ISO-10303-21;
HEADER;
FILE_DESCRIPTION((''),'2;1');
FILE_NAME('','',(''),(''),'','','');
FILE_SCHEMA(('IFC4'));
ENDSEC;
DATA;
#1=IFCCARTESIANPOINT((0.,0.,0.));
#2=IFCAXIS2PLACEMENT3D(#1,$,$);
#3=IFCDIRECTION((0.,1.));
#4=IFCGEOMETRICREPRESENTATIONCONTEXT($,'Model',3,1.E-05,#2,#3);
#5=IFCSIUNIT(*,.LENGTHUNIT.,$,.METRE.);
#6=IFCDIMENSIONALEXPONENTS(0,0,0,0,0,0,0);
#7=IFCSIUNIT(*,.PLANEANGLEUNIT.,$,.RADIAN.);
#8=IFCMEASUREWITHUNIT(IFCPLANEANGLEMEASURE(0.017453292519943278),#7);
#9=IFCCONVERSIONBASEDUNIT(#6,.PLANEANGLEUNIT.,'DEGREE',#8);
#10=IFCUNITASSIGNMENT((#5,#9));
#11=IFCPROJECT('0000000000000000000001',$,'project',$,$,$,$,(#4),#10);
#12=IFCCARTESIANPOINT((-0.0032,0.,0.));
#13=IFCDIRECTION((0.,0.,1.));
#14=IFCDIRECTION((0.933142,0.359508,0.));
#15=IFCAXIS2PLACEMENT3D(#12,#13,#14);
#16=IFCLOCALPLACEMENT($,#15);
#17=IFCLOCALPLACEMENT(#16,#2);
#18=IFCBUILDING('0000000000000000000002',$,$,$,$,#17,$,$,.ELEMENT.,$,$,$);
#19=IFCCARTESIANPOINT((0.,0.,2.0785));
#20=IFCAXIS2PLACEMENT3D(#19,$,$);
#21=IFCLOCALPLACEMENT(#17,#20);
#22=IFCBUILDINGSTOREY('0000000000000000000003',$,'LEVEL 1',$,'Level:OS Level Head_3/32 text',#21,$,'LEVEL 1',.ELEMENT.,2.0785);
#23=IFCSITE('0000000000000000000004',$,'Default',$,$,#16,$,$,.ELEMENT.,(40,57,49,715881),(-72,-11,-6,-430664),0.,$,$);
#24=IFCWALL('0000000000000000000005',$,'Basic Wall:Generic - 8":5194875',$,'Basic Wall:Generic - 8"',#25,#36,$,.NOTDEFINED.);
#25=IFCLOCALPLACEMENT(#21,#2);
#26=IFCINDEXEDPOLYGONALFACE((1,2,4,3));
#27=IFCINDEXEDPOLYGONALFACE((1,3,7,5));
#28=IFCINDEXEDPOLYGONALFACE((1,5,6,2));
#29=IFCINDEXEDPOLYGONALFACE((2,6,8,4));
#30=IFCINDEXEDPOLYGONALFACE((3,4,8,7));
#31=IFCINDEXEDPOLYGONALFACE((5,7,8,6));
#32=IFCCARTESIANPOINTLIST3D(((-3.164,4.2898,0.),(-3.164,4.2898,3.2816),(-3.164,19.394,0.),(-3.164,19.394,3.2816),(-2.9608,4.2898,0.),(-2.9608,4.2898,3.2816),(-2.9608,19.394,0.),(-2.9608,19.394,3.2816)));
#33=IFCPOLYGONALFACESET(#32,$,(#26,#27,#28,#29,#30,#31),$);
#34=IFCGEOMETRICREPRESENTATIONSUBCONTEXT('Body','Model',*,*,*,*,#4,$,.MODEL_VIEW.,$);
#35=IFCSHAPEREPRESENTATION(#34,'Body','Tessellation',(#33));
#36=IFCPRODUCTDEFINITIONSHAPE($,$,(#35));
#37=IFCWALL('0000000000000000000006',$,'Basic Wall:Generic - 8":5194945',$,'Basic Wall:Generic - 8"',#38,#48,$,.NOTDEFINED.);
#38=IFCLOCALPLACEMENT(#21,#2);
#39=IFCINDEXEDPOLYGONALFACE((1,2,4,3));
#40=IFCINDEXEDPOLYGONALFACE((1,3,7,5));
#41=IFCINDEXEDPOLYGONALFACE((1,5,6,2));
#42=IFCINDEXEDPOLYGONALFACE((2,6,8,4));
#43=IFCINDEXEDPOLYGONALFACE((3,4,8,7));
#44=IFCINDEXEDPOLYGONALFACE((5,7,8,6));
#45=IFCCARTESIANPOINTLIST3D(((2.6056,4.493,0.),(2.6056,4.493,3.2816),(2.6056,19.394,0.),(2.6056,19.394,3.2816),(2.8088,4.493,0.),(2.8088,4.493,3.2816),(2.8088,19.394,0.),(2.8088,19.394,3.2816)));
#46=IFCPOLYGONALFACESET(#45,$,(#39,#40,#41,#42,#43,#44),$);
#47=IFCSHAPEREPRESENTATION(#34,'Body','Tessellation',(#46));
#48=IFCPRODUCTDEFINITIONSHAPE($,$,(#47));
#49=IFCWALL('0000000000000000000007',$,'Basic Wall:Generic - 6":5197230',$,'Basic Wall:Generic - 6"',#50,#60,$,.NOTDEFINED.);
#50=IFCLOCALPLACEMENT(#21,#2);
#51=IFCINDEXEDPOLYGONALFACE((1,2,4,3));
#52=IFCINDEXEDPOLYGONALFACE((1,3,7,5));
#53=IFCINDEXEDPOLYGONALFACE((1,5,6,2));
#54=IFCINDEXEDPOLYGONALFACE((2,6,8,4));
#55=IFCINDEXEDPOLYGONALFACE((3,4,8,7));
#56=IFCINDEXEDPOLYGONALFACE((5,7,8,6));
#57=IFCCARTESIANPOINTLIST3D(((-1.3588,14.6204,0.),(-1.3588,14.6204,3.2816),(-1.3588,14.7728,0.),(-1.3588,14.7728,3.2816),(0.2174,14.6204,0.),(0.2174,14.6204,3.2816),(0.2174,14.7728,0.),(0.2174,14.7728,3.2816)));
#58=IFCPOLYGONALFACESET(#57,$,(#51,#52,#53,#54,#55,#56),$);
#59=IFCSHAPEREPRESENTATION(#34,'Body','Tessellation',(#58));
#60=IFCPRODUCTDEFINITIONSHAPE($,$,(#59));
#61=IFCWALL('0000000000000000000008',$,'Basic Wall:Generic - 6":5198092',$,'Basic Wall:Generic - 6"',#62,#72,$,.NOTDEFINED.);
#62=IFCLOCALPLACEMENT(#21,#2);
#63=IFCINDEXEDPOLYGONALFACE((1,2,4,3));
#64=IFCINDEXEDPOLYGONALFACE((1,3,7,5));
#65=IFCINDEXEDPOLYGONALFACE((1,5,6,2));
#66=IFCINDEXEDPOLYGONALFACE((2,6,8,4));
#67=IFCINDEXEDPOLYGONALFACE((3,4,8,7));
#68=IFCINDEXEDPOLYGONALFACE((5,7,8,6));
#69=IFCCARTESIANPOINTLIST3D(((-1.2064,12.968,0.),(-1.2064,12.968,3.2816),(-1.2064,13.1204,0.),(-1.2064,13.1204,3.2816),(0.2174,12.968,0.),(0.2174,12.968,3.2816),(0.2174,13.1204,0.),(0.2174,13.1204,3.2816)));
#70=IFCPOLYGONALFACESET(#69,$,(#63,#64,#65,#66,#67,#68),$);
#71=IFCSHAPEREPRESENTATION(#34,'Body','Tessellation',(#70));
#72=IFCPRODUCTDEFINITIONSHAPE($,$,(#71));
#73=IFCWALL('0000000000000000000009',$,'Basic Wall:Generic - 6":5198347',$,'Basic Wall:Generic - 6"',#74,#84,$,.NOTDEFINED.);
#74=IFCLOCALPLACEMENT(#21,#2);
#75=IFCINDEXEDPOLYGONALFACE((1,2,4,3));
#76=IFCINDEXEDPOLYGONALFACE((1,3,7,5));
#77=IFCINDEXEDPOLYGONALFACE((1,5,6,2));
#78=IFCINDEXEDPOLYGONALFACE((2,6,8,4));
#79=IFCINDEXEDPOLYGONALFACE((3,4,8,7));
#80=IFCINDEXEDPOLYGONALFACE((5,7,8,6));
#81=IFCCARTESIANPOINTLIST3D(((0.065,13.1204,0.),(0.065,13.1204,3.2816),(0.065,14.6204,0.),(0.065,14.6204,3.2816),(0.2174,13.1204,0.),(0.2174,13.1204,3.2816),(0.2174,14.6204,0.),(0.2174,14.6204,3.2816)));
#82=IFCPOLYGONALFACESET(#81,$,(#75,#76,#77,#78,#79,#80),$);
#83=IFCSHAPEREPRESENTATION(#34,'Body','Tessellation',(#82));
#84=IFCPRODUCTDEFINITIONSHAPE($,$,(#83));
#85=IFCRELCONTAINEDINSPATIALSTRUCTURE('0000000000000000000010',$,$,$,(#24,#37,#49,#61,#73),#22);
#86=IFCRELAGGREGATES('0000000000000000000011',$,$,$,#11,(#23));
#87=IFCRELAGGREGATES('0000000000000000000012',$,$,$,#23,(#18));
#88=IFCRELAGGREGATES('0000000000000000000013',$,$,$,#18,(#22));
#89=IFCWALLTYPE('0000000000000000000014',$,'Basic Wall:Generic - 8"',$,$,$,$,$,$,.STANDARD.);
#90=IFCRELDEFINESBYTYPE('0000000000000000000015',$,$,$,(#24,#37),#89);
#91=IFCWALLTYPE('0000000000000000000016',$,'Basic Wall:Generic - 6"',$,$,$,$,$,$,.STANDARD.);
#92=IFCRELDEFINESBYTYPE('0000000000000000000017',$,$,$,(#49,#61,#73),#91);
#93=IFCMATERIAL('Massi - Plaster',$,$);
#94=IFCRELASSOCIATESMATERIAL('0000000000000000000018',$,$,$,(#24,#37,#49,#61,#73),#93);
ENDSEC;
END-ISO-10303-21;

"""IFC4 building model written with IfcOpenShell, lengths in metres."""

from ifc_helpers import new_model, entity, si_unit, converted_unit, direction, frame, origin, place, context, subcontext, project, spatial, indexed_curve, outline, extrude, material, type_object, element, save


model = new_model("IFC4")

# Units and contexts
model_context = context("Model", 3, precision=1e-05, world=origin(), true_north=direction((0.0, 1.0)))
body_context = subcontext(model_context, "Body", "Model", "MODEL_VIEW")
ifc_project = project(units=[si_unit("LENGTHUNIT", "METRE"), converted_unit("PLANEANGLEUNIT", "DEGREE", entity("IfcPlaneAngleMeasure", 0.017453292519943278), si_unit("PLANEANGLEUNIT", "RADIAN"), dimensions=[0, 0, 0, 0, 0, 0, 0])], contexts=[model_context])

# Site, building, storey
site_placement = place(None, frame((-0.0032, 0.0, 0.0), z_axis=(0.0, 0.0, 1.0), x_axis=(0.933142, 0.359508, 0.0)))
site = spatial("IfcSite", under=ifc_project, at=site_placement, Name="Default", CompositionType="ELEMENT", RefLatitude=(40, 57, 49, 715881), RefLongitude=(-72, -11, -6, -430664), RefElevation=0.0)
building_placement = place(site_placement, origin())
building = spatial("IfcBuilding", under=site, at=building_placement, CompositionType="ELEMENT")
storey_placement = place(building_placement, frame((0.0, 0.0, 2.0785)))
storey = spatial("IfcBuildingStorey", under=building, at=storey_placement, Name="LEVEL 1", ObjectType="Level:OS Level Head_3/32 text", LongName="LEVEL 1", CompositionType="ELEMENT", Elevation=2.0785)

# Walls
ifc_material_1 = material(Name="Massi - Plaster")
wall_type_1 = type_object("IfcWallType", Name="Basic Wall:Generic - 8\"", PredefinedType="STANDARD")
wall_1_placement = place(storey_placement, frame((-3.0624, 4.2898, 0.0), z_axis=(0.0, 0.0, 1.0), x_axis=(0.0, 1.0, 0.0)))
element("IfcWall", 1, at=wall_1_placement, inside=storey, type_object=wall_type_1, material=ifc_material_1, Name="Basic Wall:Generic - 8\":5194875", ObjectType="Basic Wall:Generic - 8\"", PredefinedType="NOTDEFINED", context=body_context, shape_type="SweptSolid", body=[
    extrude(outline(indexed_curve([(15.1042, 0.1016), (0.0, 0.1016), (0.0, -0.1016), (15.1042, -0.1016), (15.1042, 0.1016)], self_intersect=False)), origin(), (0.0, 0.0, 1.0), 3.2816),
])
wall_2_placement = place(storey_placement, frame((2.7072, 19.394, 0.0), z_axis=(0.0, 0.0, 1.0), x_axis=(0.0, -1.0, 0.0)))
element("IfcWall", 2, at=wall_2_placement, inside=storey, type_object=wall_type_1, material=ifc_material_1, Name="Basic Wall:Generic - 8\":5194945", ObjectType="Basic Wall:Generic - 8\"", PredefinedType="NOTDEFINED", context=body_context, shape_type="SweptSolid", body=[
    extrude(outline(indexed_curve([(14.901, 0.1016), (0.0, 0.1016), (0.0, -0.1016), (14.901, -0.1016), (14.901, 0.1016)], self_intersect=False)), origin(), (0.0, 0.0, 1.0), 3.2816),
])
wall_type_2 = type_object("IfcWallType", Name="Basic Wall:Generic - 6\"", PredefinedType="STANDARD")
wall_3_placement = place(storey_placement, frame((0.2174, 14.6966, 0.0), z_axis=(0.0, 0.0, 1.0), x_axis=(-1.0, 0.0, 0.0)))
element("IfcWall", 3, at=wall_3_placement, inside=storey, type_object=wall_type_2, material=ifc_material_1, Name="Basic Wall:Generic - 6\":5197230", ObjectType="Basic Wall:Generic - 6\"", PredefinedType="NOTDEFINED", context=body_context, shape_type="SweptSolid", body=[
    extrude(outline(indexed_curve([(1.5762, 0.0762), (0.0, 0.0762), (0.0, -0.0762), (1.5762, -0.0762), (1.5762, 0.0762)], self_intersect=False)), origin(), (0.0, 0.0, 1.0), 3.2816),
])
wall_4_placement = place(storey_placement, frame((0.2174, 13.0442, 0.0), z_axis=(0.0, 0.0, 1.0), x_axis=(-1.0, 0.0, 0.0)))
element("IfcWall", 4, at=wall_4_placement, inside=storey, type_object=wall_type_2, material=ifc_material_1, Name="Basic Wall:Generic - 6\":5198092", ObjectType="Basic Wall:Generic - 6\"", PredefinedType="NOTDEFINED", context=body_context, shape_type="SweptSolid", body=[
    extrude(outline(indexed_curve([(1.4238, 0.0762), (0.0, 0.0762), (0.0, -0.0762), (1.4238, -0.0762), (1.4238, 0.0762)], self_intersect=False)), origin(), (0.0, 0.0, 1.0), 3.2816),
])
wall_5_placement = place(storey_placement, frame((0.1412, 14.6204, 0.0), z_axis=(0.0, 0.0, 1.0), x_axis=(0.0, -1.0, 0.0)))
element("IfcWall", 5, at=wall_5_placement, inside=storey, type_object=wall_type_2, material=ifc_material_1, Name="Basic Wall:Generic - 6\":5198347", ObjectType="Basic Wall:Generic - 6\"", PredefinedType="NOTDEFINED", context=body_context, shape_type="SweptSolid", body=[
    extrude(outline(indexed_curve([(1.5, 0.0762), (0.0, 0.0762), (0.0, -0.0762), (1.5, -0.0762), (1.5, 0.0762)], self_intersect=False)), origin(), (0.0, 0.0, 1.0), 3.2816),
])

save(model, "model.ifc")
